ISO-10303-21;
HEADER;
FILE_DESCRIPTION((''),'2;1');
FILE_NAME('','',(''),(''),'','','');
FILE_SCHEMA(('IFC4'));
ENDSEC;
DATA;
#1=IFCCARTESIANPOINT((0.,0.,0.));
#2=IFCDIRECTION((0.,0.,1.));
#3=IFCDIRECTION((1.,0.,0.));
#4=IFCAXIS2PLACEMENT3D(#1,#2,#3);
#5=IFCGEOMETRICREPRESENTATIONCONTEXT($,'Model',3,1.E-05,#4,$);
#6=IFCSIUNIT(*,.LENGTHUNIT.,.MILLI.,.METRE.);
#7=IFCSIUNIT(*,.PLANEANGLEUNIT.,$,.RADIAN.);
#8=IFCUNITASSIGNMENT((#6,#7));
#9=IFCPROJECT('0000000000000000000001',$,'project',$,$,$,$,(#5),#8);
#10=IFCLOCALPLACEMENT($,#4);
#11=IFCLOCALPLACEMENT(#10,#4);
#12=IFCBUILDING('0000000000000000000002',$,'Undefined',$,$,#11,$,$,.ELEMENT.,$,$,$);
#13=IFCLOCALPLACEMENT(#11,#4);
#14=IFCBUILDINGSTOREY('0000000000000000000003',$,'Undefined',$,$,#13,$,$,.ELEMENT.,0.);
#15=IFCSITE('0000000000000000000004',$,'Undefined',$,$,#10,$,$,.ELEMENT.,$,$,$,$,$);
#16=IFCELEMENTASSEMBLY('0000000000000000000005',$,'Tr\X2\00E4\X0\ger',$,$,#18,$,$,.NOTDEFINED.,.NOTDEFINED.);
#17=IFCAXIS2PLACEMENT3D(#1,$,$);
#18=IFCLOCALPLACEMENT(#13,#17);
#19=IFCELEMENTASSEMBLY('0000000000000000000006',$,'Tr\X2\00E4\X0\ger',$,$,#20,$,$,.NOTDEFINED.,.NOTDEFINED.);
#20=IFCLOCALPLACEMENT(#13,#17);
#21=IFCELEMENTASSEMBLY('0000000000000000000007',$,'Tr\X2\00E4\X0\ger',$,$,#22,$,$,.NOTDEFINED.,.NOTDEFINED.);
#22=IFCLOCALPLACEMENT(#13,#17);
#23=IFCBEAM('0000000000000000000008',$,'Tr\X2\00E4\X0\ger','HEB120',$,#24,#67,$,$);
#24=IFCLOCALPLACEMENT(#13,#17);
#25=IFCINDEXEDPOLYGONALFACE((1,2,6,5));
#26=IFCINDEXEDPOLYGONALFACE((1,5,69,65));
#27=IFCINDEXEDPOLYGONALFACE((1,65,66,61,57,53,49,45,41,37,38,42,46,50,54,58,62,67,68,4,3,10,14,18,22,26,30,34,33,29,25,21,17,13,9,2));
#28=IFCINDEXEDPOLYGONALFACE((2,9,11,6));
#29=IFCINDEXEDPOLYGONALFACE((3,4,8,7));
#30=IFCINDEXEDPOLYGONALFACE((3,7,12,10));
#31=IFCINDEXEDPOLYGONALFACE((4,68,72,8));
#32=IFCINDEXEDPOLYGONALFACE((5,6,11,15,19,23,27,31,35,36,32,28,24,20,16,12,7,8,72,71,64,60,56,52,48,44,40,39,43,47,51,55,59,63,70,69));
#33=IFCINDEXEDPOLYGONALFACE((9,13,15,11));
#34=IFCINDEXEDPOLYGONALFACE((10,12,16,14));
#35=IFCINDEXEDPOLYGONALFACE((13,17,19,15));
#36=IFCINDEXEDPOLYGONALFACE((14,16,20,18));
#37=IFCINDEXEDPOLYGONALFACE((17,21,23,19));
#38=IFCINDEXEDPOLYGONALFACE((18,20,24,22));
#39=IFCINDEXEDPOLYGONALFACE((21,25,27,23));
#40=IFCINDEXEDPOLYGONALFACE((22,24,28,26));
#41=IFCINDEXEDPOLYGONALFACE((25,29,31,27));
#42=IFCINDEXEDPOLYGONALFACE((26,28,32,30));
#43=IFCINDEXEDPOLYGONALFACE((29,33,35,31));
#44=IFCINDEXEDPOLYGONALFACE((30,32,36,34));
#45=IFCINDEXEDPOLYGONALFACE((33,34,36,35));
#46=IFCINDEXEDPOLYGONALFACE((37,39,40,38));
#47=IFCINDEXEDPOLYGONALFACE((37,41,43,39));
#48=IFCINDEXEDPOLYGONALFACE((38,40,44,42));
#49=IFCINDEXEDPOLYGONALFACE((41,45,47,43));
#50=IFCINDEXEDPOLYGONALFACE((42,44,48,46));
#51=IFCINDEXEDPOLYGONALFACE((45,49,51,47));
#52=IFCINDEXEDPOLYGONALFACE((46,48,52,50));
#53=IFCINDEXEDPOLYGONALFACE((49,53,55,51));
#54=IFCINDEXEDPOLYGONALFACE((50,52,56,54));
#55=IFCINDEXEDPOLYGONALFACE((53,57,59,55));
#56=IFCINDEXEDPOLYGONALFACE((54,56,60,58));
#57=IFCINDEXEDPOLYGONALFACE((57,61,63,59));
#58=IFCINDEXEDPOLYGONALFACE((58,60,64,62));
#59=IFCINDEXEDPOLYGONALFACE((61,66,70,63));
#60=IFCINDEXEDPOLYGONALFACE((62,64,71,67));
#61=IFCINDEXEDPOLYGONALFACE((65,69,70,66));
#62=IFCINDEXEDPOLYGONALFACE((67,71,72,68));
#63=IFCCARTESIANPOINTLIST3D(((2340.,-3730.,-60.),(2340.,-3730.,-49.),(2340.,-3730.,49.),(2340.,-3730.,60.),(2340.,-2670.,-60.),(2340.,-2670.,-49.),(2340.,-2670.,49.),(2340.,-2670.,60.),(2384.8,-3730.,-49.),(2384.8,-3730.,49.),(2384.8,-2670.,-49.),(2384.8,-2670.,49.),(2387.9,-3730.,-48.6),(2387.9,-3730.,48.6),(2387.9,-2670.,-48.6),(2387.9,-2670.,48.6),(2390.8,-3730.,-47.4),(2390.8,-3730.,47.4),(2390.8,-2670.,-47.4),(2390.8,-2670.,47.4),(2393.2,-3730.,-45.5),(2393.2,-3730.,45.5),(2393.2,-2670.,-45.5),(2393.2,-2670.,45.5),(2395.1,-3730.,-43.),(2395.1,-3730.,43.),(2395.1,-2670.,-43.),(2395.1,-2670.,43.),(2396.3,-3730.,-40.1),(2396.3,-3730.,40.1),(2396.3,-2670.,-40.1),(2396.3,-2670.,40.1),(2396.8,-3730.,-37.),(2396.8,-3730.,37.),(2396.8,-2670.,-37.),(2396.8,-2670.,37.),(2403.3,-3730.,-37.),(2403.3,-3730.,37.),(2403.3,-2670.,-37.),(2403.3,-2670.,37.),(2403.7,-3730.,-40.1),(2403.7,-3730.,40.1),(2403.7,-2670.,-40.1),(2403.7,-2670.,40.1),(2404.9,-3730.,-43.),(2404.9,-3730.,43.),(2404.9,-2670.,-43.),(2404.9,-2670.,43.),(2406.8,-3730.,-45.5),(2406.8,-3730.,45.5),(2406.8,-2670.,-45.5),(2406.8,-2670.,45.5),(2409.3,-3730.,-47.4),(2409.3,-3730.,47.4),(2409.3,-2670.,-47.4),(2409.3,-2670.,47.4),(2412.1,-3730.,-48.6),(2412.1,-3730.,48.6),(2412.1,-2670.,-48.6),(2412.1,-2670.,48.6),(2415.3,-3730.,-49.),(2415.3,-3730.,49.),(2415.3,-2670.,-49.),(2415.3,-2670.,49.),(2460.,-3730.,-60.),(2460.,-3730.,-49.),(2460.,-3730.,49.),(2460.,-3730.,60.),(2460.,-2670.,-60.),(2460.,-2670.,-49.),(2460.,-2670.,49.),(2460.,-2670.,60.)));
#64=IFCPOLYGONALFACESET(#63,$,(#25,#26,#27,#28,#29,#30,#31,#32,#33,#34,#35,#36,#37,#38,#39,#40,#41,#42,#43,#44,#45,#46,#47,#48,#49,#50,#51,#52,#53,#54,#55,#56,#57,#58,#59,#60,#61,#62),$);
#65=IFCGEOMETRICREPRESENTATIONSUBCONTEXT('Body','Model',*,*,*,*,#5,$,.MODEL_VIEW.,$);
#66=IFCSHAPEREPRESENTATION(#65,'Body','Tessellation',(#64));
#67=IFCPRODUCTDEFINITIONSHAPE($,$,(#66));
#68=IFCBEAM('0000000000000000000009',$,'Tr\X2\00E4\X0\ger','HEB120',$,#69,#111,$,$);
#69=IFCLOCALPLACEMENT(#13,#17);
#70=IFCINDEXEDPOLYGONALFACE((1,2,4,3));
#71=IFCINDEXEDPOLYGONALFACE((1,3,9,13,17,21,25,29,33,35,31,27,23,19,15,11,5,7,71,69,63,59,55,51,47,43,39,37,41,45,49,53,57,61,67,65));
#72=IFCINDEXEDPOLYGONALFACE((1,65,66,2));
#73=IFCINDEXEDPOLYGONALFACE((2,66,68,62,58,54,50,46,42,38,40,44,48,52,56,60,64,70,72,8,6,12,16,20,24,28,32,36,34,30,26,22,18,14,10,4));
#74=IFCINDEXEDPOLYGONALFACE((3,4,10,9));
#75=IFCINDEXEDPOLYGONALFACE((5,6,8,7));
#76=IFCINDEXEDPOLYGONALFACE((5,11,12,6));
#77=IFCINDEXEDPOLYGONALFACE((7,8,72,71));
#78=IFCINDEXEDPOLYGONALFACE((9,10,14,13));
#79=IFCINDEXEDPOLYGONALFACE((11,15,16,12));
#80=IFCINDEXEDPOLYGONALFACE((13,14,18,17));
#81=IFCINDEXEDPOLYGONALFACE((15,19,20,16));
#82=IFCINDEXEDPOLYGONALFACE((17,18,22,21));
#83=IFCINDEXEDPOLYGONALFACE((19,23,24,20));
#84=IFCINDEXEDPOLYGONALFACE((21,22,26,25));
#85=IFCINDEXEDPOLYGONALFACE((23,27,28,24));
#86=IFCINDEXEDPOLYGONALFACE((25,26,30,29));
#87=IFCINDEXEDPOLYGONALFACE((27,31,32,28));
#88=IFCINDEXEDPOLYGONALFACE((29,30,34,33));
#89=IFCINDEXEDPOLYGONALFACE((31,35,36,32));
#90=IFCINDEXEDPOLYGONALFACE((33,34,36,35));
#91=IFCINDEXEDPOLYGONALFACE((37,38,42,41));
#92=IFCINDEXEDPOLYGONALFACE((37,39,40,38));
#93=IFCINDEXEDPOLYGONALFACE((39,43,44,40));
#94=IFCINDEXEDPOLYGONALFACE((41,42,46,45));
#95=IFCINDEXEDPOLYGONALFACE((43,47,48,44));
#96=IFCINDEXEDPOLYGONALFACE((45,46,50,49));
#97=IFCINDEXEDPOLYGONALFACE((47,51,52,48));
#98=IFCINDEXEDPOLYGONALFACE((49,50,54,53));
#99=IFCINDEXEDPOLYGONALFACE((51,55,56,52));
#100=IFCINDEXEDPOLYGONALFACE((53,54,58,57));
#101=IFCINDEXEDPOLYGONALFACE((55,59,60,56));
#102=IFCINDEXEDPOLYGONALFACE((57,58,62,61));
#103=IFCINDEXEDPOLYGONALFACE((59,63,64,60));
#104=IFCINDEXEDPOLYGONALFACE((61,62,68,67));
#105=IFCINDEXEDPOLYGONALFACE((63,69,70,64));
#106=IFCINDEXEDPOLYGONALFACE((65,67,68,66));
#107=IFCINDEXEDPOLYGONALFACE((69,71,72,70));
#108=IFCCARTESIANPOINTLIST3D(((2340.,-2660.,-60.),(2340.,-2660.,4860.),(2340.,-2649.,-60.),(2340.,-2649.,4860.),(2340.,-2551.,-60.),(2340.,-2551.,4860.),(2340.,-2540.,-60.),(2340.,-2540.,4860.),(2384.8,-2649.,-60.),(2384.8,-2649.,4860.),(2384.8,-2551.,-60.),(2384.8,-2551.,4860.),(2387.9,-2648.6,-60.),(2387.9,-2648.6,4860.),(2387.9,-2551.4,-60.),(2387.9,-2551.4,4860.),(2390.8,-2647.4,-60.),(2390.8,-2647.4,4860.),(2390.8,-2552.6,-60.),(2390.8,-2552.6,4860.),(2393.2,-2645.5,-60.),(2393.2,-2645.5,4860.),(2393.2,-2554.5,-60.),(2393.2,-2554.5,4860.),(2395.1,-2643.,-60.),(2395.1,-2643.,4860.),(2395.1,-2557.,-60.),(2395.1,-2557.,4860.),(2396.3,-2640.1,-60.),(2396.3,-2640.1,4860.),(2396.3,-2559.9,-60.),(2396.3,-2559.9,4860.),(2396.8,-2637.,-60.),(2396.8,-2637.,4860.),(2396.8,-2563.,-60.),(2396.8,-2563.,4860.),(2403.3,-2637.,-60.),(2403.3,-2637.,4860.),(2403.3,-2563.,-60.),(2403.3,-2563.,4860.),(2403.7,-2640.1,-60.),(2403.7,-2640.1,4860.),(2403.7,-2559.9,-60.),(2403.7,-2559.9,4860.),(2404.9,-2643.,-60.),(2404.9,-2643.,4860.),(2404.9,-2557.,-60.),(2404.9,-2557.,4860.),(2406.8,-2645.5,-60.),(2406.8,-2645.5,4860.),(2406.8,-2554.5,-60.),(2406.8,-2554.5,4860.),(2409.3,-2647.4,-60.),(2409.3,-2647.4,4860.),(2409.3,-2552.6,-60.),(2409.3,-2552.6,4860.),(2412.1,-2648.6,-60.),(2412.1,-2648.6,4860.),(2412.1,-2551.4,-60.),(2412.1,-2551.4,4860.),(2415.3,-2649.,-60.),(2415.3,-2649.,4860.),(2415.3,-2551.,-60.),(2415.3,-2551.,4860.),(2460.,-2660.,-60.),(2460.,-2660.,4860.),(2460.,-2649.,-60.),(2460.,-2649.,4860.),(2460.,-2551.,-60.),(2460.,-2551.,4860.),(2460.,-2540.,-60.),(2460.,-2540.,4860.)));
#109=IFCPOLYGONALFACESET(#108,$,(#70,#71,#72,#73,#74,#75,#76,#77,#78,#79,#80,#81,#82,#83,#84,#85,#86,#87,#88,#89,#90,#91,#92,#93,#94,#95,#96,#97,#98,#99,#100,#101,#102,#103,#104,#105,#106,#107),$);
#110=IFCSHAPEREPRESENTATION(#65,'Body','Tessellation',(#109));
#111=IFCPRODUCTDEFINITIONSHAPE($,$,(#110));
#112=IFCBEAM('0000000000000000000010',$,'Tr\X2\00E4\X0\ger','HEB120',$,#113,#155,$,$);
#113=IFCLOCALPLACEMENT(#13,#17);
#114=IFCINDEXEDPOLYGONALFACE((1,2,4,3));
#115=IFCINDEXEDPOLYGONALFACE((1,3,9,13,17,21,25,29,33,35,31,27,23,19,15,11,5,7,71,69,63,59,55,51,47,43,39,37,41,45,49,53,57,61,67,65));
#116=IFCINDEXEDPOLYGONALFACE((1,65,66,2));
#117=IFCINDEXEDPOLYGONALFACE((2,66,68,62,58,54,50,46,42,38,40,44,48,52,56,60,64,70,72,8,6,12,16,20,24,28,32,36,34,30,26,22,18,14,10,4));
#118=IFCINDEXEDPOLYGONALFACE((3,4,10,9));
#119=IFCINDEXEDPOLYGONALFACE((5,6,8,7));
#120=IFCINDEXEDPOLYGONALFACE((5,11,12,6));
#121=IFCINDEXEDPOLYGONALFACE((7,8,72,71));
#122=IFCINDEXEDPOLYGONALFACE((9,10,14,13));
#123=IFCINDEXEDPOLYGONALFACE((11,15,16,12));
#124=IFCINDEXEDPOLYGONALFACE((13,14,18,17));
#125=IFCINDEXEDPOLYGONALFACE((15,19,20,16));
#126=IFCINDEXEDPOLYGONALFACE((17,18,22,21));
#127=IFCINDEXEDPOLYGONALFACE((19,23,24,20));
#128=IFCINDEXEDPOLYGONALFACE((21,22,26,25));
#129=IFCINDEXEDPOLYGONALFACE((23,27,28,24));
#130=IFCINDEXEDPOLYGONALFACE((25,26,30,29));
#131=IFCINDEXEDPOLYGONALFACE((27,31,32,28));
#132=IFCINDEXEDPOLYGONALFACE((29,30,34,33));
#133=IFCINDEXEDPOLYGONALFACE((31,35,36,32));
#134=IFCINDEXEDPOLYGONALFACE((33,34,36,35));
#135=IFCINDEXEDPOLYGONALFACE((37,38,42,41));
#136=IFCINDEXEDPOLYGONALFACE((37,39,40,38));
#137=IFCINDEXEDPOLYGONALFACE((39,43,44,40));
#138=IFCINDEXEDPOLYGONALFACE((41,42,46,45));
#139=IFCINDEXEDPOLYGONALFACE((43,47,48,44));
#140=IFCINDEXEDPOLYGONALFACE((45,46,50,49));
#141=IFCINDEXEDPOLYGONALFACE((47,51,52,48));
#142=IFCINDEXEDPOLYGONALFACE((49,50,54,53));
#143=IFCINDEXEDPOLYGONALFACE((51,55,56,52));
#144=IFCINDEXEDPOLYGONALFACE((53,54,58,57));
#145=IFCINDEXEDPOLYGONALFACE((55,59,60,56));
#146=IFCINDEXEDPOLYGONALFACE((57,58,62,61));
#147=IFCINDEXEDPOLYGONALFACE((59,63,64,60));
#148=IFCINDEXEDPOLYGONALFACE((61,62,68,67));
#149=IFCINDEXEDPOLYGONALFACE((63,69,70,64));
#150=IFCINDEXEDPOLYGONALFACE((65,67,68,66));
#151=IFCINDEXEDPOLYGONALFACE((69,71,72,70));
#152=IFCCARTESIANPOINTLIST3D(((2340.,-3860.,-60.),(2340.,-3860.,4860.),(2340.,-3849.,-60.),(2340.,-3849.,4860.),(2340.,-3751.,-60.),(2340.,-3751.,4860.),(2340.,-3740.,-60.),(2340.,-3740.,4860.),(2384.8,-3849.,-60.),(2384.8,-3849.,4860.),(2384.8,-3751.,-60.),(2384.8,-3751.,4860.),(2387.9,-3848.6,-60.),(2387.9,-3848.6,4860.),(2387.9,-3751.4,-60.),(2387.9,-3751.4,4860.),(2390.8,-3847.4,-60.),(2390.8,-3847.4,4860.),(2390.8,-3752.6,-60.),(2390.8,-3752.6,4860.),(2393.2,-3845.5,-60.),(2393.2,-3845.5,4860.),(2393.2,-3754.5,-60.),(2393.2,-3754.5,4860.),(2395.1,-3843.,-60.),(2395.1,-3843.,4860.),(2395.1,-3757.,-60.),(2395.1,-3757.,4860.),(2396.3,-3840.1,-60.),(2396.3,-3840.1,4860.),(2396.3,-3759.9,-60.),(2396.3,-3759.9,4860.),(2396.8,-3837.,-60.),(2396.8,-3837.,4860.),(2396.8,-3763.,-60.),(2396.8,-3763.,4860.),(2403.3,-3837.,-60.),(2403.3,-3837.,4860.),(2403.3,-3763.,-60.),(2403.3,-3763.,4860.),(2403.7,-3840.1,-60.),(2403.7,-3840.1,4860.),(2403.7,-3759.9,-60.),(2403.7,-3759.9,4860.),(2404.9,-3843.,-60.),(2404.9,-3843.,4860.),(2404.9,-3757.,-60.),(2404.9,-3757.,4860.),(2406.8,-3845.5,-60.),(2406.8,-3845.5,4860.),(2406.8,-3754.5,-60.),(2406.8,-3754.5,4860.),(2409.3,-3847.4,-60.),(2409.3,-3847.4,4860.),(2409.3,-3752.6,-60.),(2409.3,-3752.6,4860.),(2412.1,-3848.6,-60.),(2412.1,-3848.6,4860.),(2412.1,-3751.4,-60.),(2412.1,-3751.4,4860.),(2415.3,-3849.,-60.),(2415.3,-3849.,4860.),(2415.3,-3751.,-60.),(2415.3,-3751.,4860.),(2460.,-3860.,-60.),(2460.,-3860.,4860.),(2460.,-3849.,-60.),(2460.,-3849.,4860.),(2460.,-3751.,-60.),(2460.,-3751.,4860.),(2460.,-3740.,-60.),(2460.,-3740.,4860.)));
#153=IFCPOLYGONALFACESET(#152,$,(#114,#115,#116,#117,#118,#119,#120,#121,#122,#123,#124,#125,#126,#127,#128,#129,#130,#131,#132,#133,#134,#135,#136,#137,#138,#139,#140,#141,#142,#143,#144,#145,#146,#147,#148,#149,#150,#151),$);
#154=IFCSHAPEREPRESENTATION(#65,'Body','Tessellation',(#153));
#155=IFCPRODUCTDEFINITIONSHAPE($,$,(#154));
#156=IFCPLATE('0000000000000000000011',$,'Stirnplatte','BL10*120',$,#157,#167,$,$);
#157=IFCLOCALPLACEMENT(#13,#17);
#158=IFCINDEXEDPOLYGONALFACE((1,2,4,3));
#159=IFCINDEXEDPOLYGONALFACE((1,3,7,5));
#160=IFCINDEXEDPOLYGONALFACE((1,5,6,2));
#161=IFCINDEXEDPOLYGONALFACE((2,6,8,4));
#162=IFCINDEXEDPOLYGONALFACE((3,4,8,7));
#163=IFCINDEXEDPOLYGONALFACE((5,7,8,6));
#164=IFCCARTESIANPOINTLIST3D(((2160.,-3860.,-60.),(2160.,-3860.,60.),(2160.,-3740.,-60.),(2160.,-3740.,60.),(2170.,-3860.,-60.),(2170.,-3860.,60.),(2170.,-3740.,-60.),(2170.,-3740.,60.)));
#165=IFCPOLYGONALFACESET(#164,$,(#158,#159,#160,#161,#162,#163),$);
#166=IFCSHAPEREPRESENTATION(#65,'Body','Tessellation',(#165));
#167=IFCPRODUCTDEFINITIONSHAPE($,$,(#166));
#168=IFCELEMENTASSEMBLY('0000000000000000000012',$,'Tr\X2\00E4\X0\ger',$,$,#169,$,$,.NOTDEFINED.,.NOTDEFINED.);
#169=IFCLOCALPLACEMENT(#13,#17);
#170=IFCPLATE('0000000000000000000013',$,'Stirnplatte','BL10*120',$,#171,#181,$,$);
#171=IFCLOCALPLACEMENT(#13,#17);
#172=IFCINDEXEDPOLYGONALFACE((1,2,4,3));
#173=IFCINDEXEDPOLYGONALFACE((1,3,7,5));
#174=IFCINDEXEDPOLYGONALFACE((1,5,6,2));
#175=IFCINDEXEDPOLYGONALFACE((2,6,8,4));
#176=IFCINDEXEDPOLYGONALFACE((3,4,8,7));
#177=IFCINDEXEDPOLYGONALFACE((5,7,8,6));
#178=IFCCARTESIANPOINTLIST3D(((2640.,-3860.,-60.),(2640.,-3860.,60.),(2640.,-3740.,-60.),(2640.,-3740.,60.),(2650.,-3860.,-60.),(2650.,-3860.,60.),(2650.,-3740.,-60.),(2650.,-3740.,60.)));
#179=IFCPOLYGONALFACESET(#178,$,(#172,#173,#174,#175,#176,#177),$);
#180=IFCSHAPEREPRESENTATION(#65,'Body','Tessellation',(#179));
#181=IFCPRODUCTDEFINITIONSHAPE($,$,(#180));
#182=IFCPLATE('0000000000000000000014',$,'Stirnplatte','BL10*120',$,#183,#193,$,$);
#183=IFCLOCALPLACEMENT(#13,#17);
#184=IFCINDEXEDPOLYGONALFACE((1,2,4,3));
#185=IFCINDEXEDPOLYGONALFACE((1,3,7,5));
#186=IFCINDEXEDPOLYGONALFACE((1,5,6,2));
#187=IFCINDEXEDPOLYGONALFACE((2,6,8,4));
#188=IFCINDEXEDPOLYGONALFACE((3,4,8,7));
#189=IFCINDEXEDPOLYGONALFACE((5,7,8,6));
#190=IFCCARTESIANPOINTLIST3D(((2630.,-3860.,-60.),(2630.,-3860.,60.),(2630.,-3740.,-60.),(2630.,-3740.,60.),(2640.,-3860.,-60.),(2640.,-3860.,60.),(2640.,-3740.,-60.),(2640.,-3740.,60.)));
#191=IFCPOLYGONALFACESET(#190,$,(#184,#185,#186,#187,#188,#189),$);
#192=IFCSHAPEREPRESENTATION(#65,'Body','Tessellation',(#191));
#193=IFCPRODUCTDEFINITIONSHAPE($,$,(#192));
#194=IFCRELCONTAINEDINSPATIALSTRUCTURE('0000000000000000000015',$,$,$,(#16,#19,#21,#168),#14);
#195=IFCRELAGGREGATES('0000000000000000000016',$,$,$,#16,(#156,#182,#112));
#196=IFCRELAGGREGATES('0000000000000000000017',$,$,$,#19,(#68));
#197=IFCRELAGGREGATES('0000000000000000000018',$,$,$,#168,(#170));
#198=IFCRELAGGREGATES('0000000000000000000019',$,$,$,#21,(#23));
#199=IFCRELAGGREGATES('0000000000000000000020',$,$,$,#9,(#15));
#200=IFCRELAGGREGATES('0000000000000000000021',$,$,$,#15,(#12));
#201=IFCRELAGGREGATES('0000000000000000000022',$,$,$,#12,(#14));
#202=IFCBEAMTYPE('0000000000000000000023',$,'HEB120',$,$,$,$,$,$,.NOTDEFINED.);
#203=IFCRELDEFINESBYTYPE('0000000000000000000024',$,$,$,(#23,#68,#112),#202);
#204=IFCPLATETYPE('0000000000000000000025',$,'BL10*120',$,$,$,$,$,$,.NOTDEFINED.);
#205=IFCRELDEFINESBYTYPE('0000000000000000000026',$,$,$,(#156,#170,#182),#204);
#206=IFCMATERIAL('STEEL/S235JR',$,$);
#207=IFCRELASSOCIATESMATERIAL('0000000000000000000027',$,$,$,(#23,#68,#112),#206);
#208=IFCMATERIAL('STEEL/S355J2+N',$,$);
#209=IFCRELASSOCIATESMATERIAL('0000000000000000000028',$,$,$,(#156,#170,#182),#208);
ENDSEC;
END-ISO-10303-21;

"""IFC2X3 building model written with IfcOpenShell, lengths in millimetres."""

from ifc_helpers import new_model, si_unit, frame, origin_with_axes, origin_2d_with_axis, place, context, subcontext, project, spatial, polyline, i_section, outline, extrude, clip, halfspace, material, type_object, element, aggregate, save


model = new_model("IFC2X3")

# Units and contexts
model_context = context("Model", 3, precision=1e-05, world=origin_with_axes())
body_context = subcontext(model_context, "Body", "Model", "MODEL_VIEW")
ifc_project = project(units=[si_unit("LENGTHUNIT", "METRE", prefix="MILLI"), si_unit("PLANEANGLEUNIT", "RADIAN")], contexts=[model_context])

# Site, building, storey
site_placement = place(None, origin_with_axes())
site = spatial("IfcSite", under=ifc_project, at=site_placement, Name="Undefined", CompositionType="ELEMENT")
building_placement = place(site_placement, origin_with_axes())
building = spatial("IfcBuilding", under=site, at=building_placement, Name="Undefined", CompositionType="ELEMENT")
storey_placement = place(building_placement, origin_with_axes())
storey = spatial("IfcBuildingStorey", under=building, at=storey_placement, Name="Undefined", CompositionType="ELEMENT", Elevation=0.0)

# Element assemblies, beam
assembly_1_placement = place(storey_placement, origin_with_axes())
assembly_1 = element("IfcElementAssembly", 1, at=assembly_1_placement, inside=storey, Name="Träger", AssemblyPlace="NOTDEFINED", PredefinedType="NOTDEFINED")
ifc_material_1 = material(Name="STEEL/S235JR")
beam_type = type_object("IfcBeamType", Name="HEB120", PredefinedType="NOTDEFINED")
assembly_2_placement = place(storey_placement, origin_with_axes())
assembly_2 = element("IfcElementAssembly", 2, at=assembly_2_placement, inside=storey, Name="Träger", AssemblyPlace="NOTDEFINED", PredefinedType="NOTDEFINED")
assembly_3_placement = place(storey_placement, origin_with_axes())
assembly_3 = element("IfcElementAssembly", 3, at=assembly_3_placement, inside=storey, Name="Träger", AssemblyPlace="NOTDEFINED", PredefinedType="NOTDEFINED")
beam_1_placement = place(assembly_3_placement, frame((2400.0, -2670.0, 0.0), z_axis=(0.0, 0.0, 1.0), x_axis=(0.0, -1.0, 0.0)))
beam_1 = element("IfcBeam", 4, at=beam_1_placement, type_object=beam_type, material=ifc_material_1, Name="Träger", Description="HEB120", context=body_context, shape_type="Clipping", body=[
    clip(clip(extrude(i_section(OverallWidth=120.0, OverallDepth=120.0, WebThickness=6.5, FlangeThickness=11.0, FilletRadius=12.0, at=origin_2d_with_axis()), frame((1060.0, 0.0, 0.0), z_axis=(-1.0, 0.0, 0.0), x_axis=(0.0, -1.0, 0.0)), (0.0, 0.0, 1.0), 1060.0), halfspace(frame((1060.0, 0.0, -60.0), z_axis=(-1.0, 0.0, 0.0), x_axis=(0.0, 1.0, 0.0)), True)), halfspace(frame((0.0, 0.0, -60.0), z_axis=(1.0, 0.0, 0.0), x_axis=(0.0, -1.0, 0.0)), True)),
])

# Beams
beam_2_placement = place(assembly_2_placement, frame((2400.0, -2600.0, -60.0), z_axis=(0.0, 1.0, 0.0), x_axis=(0.0, 0.0, 1.0)))
beam_2 = element("IfcBeam", 5, at=beam_2_placement, type_object=beam_type, material=ifc_material_1, Name="Träger", Description="HEB120", context=body_context, shape_type="SweptSolid", body=[
    extrude(i_section(OverallWidth=120.0, OverallDepth=120.0, WebThickness=6.5, FlangeThickness=11.0, FilletRadius=12.0, at=origin_2d_with_axis()), frame((4920.0, 0.0, 0.0), z_axis=(-1.0, 0.0, 0.0), x_axis=(0.0, -1.0, 0.0)), (0.0, 0.0, 1.0), 4920.0),
])
beam_3_placement = place(assembly_1_placement, frame((2400.0, -3800.0, -60.0), z_axis=(0.0, 1.0, 0.0), x_axis=(0.0, 0.0, 1.0)))
beam_3 = element("IfcBeam", 6, at=beam_3_placement, type_object=beam_type, material=ifc_material_1, Name="Träger", Description="HEB120", context=body_context, shape_type="SweptSolid", body=[
    extrude(i_section(OverallWidth=120.0, OverallDepth=120.0, WebThickness=6.5, FlangeThickness=11.0, FilletRadius=12.0, at=origin_2d_with_axis()), frame((4920.0, 0.0, 0.0), z_axis=(-1.0, 0.0, 0.0), x_axis=(0.0, -1.0, 0.0)), (0.0, 0.0, 1.0), 4920.0),
])

# Plate
ifc_material_2 = material(Name="STEEL/S355J2+N")
plate_type = type_object("IfcPlateType", Name="BL10*120", PredefinedType="NOTDEFINED")
plate_1_placement = place(assembly_1_placement, frame((2165.0, -3800.0, -60.0), z_axis=(-1.0, 0.0, 0.0), x_axis=(0.0, 0.0, 1.0)))
plate_1 = element("IfcPlate", 7, at=plate_1_placement, type_object=plate_type, material=ifc_material_2, Name="Stirnplatte", Description="BL10*120", context=body_context, shape_type="SweptSolid", body=[
    extrude(outline(polyline([(0.0, -60.0), (0.0, 60.0), (120.0, 60.0), (120.0, -60.0), (0.0, -60.0)])), frame((0.0, 0.0, -5.0), z_axis=(0.0, 0.0, 1.0), x_axis=(1.0, 0.0, 0.0)), (0.0, 0.0, 1.0), 10.0),
])

# Element assembly, plate
assembly_4_placement = place(storey_placement, origin_with_axes())
assembly_4 = element("IfcElementAssembly", 8, at=assembly_4_placement, inside=storey, Name="Träger", AssemblyPlace="NOTDEFINED", PredefinedType="NOTDEFINED")
plate_2_placement = place(assembly_4_placement, frame((2645.0, -3800.0, -60.0), z_axis=(1.0, 0.0, 0.0), x_axis=(0.0, 0.0, 1.0)))
plate_2 = element("IfcPlate", 9, at=plate_2_placement, type_object=plate_type, material=ifc_material_2, Name="Stirnplatte", Description="BL10*120", context=body_context, shape_type="SweptSolid", body=[
    extrude(outline(polyline([(0.0, -60.0), (0.0, 60.0), (120.0, 60.0), (120.0, -60.0), (0.0, -60.0)])), frame((0.0, 0.0, -5.0), z_axis=(0.0, 0.0, 1.0), x_axis=(1.0, 0.0, 0.0)), (0.0, 0.0, 1.0), 10.0),
])

# Plate
plate_3_placement = place(assembly_1_placement, frame((2635.0, -3800.0, -60.0), z_axis=(1.0, 0.0, 0.0), x_axis=(0.0, 0.0, 1.0)))
plate_3 = element("IfcPlate", 10, at=plate_3_placement, type_object=plate_type, material=ifc_material_2, Name="Stirnplatte", Description="BL10*120", context=body_context, shape_type="SweptSolid", body=[
    extrude(outline(polyline([(0.0, -60.0), (0.0, 60.0), (120.0, 60.0), (120.0, -60.0), (0.0, -60.0)])), frame((0.0, 0.0, -5.0), z_axis=(0.0, 0.0, 1.0), x_axis=(1.0, 0.0, 0.0)), (0.0, 0.0, 1.0), 10.0),
])
aggregate(assembly_1, [plate_1, plate_3, beam_3])

aggregate(assembly_2, [beam_2])

aggregate(assembly_4, [plate_2])
aggregate(assembly_3, [beam_1])

save(model, "model.ifc")
